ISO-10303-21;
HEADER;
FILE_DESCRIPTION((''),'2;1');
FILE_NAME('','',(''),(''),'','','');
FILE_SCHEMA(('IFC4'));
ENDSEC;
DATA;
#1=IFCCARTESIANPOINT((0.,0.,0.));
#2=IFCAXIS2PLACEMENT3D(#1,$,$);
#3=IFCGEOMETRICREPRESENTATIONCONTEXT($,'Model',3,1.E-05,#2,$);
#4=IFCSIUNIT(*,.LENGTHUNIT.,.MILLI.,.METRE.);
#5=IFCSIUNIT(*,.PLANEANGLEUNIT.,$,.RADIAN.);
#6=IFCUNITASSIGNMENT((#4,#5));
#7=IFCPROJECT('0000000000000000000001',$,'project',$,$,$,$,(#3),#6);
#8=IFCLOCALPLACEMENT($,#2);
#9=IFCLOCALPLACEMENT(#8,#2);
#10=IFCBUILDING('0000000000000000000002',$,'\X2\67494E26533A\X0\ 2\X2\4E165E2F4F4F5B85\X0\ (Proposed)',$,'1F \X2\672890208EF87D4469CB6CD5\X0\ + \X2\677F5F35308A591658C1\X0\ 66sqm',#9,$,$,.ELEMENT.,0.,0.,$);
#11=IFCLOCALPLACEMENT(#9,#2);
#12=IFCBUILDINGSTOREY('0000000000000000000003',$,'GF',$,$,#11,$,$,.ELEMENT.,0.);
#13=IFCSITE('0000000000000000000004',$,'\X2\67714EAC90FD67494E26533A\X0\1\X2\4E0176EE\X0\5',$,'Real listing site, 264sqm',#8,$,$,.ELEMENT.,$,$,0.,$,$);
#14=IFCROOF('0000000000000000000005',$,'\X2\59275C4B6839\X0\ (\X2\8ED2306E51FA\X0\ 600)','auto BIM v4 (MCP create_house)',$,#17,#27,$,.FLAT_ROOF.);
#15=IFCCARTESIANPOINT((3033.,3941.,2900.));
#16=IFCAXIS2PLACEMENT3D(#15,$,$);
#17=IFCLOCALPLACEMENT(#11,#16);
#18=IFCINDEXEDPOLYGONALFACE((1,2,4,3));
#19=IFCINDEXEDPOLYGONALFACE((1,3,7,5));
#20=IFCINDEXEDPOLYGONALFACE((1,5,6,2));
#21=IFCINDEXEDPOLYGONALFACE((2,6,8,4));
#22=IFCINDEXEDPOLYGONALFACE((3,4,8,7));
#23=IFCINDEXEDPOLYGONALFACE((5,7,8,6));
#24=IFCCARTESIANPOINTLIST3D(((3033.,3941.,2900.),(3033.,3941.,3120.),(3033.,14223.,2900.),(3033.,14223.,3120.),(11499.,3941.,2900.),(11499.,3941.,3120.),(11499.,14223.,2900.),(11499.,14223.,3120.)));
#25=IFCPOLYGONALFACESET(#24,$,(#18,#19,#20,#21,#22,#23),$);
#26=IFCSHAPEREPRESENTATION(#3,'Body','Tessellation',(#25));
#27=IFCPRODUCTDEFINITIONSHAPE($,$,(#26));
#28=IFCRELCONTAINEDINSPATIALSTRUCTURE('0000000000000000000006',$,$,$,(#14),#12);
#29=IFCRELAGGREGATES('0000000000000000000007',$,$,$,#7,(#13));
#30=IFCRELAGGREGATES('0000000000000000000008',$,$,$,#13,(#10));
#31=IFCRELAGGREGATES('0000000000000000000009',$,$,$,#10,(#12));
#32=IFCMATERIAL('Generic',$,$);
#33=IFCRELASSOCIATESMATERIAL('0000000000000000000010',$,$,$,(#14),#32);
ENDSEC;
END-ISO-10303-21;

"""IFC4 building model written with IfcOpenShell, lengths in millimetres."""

from ifc_helpers import new_model, si_unit, frame, frame_2d, origin, place, context, project, spatial, rectangle, extrude, material, element, save


model = new_model("IFC4")

# Units and contexts
model_context = context("Model", 3, precision=1e-05, world=origin())
ifc_project = project(units=[si_unit("LENGTHUNIT", "METRE", prefix="MILLI"), si_unit("PLANEANGLEUNIT", "RADIAN")], contexts=[model_context])

# Site, building, storey
site_placement = place(None, origin())
site = spatial("IfcSite", under=ifc_project, at=site_placement, Name="東京都杉並区1丁目5", ObjectType="Real listing site, 264sqm", CompositionType="ELEMENT", RefElevation=0.0)
building_placement = place(site_placement, origin())
building = spatial("IfcBuilding", under=site, at=building_placement, Name="杉並区 2世帯住宅 (Proposed)", ObjectType="1F 木造軸組構法 + 板張り外壁 66sqm", CompositionType="ELEMENT", ElevationOfRefHeight=0.0, ElevationOfTerrain=0.0)
storey_placement = place(building_placement, origin())
storey = spatial("IfcBuildingStorey", under=building, at=storey_placement, Name="GF", CompositionType="ELEMENT", Elevation=0.0)

# Shared definitions
ifc_material = material(Name="Generic")

# Roof
roof_placement = place(storey_placement, frame((3033.0, 3941.0, 2900.0)))
element("IfcRoof", 1, at=roof_placement, inside=storey, material=ifc_material, Name="大屋根 (軒の出 600)", Description="auto BIM v4 (MCP create_house)", PredefinedType="FLAT_ROOF", context=model_context, shape_type="SweptSolid", body=[
    extrude(rectangle(XDim=8466.0, YDim=10282.0, at=frame_2d((4233.0, 5141.0))), frame((3033.0, 3941.0, 2900.0)), (0.0, 0.0, 1.0), 220.0),
])

save(model, "model.ifc")
